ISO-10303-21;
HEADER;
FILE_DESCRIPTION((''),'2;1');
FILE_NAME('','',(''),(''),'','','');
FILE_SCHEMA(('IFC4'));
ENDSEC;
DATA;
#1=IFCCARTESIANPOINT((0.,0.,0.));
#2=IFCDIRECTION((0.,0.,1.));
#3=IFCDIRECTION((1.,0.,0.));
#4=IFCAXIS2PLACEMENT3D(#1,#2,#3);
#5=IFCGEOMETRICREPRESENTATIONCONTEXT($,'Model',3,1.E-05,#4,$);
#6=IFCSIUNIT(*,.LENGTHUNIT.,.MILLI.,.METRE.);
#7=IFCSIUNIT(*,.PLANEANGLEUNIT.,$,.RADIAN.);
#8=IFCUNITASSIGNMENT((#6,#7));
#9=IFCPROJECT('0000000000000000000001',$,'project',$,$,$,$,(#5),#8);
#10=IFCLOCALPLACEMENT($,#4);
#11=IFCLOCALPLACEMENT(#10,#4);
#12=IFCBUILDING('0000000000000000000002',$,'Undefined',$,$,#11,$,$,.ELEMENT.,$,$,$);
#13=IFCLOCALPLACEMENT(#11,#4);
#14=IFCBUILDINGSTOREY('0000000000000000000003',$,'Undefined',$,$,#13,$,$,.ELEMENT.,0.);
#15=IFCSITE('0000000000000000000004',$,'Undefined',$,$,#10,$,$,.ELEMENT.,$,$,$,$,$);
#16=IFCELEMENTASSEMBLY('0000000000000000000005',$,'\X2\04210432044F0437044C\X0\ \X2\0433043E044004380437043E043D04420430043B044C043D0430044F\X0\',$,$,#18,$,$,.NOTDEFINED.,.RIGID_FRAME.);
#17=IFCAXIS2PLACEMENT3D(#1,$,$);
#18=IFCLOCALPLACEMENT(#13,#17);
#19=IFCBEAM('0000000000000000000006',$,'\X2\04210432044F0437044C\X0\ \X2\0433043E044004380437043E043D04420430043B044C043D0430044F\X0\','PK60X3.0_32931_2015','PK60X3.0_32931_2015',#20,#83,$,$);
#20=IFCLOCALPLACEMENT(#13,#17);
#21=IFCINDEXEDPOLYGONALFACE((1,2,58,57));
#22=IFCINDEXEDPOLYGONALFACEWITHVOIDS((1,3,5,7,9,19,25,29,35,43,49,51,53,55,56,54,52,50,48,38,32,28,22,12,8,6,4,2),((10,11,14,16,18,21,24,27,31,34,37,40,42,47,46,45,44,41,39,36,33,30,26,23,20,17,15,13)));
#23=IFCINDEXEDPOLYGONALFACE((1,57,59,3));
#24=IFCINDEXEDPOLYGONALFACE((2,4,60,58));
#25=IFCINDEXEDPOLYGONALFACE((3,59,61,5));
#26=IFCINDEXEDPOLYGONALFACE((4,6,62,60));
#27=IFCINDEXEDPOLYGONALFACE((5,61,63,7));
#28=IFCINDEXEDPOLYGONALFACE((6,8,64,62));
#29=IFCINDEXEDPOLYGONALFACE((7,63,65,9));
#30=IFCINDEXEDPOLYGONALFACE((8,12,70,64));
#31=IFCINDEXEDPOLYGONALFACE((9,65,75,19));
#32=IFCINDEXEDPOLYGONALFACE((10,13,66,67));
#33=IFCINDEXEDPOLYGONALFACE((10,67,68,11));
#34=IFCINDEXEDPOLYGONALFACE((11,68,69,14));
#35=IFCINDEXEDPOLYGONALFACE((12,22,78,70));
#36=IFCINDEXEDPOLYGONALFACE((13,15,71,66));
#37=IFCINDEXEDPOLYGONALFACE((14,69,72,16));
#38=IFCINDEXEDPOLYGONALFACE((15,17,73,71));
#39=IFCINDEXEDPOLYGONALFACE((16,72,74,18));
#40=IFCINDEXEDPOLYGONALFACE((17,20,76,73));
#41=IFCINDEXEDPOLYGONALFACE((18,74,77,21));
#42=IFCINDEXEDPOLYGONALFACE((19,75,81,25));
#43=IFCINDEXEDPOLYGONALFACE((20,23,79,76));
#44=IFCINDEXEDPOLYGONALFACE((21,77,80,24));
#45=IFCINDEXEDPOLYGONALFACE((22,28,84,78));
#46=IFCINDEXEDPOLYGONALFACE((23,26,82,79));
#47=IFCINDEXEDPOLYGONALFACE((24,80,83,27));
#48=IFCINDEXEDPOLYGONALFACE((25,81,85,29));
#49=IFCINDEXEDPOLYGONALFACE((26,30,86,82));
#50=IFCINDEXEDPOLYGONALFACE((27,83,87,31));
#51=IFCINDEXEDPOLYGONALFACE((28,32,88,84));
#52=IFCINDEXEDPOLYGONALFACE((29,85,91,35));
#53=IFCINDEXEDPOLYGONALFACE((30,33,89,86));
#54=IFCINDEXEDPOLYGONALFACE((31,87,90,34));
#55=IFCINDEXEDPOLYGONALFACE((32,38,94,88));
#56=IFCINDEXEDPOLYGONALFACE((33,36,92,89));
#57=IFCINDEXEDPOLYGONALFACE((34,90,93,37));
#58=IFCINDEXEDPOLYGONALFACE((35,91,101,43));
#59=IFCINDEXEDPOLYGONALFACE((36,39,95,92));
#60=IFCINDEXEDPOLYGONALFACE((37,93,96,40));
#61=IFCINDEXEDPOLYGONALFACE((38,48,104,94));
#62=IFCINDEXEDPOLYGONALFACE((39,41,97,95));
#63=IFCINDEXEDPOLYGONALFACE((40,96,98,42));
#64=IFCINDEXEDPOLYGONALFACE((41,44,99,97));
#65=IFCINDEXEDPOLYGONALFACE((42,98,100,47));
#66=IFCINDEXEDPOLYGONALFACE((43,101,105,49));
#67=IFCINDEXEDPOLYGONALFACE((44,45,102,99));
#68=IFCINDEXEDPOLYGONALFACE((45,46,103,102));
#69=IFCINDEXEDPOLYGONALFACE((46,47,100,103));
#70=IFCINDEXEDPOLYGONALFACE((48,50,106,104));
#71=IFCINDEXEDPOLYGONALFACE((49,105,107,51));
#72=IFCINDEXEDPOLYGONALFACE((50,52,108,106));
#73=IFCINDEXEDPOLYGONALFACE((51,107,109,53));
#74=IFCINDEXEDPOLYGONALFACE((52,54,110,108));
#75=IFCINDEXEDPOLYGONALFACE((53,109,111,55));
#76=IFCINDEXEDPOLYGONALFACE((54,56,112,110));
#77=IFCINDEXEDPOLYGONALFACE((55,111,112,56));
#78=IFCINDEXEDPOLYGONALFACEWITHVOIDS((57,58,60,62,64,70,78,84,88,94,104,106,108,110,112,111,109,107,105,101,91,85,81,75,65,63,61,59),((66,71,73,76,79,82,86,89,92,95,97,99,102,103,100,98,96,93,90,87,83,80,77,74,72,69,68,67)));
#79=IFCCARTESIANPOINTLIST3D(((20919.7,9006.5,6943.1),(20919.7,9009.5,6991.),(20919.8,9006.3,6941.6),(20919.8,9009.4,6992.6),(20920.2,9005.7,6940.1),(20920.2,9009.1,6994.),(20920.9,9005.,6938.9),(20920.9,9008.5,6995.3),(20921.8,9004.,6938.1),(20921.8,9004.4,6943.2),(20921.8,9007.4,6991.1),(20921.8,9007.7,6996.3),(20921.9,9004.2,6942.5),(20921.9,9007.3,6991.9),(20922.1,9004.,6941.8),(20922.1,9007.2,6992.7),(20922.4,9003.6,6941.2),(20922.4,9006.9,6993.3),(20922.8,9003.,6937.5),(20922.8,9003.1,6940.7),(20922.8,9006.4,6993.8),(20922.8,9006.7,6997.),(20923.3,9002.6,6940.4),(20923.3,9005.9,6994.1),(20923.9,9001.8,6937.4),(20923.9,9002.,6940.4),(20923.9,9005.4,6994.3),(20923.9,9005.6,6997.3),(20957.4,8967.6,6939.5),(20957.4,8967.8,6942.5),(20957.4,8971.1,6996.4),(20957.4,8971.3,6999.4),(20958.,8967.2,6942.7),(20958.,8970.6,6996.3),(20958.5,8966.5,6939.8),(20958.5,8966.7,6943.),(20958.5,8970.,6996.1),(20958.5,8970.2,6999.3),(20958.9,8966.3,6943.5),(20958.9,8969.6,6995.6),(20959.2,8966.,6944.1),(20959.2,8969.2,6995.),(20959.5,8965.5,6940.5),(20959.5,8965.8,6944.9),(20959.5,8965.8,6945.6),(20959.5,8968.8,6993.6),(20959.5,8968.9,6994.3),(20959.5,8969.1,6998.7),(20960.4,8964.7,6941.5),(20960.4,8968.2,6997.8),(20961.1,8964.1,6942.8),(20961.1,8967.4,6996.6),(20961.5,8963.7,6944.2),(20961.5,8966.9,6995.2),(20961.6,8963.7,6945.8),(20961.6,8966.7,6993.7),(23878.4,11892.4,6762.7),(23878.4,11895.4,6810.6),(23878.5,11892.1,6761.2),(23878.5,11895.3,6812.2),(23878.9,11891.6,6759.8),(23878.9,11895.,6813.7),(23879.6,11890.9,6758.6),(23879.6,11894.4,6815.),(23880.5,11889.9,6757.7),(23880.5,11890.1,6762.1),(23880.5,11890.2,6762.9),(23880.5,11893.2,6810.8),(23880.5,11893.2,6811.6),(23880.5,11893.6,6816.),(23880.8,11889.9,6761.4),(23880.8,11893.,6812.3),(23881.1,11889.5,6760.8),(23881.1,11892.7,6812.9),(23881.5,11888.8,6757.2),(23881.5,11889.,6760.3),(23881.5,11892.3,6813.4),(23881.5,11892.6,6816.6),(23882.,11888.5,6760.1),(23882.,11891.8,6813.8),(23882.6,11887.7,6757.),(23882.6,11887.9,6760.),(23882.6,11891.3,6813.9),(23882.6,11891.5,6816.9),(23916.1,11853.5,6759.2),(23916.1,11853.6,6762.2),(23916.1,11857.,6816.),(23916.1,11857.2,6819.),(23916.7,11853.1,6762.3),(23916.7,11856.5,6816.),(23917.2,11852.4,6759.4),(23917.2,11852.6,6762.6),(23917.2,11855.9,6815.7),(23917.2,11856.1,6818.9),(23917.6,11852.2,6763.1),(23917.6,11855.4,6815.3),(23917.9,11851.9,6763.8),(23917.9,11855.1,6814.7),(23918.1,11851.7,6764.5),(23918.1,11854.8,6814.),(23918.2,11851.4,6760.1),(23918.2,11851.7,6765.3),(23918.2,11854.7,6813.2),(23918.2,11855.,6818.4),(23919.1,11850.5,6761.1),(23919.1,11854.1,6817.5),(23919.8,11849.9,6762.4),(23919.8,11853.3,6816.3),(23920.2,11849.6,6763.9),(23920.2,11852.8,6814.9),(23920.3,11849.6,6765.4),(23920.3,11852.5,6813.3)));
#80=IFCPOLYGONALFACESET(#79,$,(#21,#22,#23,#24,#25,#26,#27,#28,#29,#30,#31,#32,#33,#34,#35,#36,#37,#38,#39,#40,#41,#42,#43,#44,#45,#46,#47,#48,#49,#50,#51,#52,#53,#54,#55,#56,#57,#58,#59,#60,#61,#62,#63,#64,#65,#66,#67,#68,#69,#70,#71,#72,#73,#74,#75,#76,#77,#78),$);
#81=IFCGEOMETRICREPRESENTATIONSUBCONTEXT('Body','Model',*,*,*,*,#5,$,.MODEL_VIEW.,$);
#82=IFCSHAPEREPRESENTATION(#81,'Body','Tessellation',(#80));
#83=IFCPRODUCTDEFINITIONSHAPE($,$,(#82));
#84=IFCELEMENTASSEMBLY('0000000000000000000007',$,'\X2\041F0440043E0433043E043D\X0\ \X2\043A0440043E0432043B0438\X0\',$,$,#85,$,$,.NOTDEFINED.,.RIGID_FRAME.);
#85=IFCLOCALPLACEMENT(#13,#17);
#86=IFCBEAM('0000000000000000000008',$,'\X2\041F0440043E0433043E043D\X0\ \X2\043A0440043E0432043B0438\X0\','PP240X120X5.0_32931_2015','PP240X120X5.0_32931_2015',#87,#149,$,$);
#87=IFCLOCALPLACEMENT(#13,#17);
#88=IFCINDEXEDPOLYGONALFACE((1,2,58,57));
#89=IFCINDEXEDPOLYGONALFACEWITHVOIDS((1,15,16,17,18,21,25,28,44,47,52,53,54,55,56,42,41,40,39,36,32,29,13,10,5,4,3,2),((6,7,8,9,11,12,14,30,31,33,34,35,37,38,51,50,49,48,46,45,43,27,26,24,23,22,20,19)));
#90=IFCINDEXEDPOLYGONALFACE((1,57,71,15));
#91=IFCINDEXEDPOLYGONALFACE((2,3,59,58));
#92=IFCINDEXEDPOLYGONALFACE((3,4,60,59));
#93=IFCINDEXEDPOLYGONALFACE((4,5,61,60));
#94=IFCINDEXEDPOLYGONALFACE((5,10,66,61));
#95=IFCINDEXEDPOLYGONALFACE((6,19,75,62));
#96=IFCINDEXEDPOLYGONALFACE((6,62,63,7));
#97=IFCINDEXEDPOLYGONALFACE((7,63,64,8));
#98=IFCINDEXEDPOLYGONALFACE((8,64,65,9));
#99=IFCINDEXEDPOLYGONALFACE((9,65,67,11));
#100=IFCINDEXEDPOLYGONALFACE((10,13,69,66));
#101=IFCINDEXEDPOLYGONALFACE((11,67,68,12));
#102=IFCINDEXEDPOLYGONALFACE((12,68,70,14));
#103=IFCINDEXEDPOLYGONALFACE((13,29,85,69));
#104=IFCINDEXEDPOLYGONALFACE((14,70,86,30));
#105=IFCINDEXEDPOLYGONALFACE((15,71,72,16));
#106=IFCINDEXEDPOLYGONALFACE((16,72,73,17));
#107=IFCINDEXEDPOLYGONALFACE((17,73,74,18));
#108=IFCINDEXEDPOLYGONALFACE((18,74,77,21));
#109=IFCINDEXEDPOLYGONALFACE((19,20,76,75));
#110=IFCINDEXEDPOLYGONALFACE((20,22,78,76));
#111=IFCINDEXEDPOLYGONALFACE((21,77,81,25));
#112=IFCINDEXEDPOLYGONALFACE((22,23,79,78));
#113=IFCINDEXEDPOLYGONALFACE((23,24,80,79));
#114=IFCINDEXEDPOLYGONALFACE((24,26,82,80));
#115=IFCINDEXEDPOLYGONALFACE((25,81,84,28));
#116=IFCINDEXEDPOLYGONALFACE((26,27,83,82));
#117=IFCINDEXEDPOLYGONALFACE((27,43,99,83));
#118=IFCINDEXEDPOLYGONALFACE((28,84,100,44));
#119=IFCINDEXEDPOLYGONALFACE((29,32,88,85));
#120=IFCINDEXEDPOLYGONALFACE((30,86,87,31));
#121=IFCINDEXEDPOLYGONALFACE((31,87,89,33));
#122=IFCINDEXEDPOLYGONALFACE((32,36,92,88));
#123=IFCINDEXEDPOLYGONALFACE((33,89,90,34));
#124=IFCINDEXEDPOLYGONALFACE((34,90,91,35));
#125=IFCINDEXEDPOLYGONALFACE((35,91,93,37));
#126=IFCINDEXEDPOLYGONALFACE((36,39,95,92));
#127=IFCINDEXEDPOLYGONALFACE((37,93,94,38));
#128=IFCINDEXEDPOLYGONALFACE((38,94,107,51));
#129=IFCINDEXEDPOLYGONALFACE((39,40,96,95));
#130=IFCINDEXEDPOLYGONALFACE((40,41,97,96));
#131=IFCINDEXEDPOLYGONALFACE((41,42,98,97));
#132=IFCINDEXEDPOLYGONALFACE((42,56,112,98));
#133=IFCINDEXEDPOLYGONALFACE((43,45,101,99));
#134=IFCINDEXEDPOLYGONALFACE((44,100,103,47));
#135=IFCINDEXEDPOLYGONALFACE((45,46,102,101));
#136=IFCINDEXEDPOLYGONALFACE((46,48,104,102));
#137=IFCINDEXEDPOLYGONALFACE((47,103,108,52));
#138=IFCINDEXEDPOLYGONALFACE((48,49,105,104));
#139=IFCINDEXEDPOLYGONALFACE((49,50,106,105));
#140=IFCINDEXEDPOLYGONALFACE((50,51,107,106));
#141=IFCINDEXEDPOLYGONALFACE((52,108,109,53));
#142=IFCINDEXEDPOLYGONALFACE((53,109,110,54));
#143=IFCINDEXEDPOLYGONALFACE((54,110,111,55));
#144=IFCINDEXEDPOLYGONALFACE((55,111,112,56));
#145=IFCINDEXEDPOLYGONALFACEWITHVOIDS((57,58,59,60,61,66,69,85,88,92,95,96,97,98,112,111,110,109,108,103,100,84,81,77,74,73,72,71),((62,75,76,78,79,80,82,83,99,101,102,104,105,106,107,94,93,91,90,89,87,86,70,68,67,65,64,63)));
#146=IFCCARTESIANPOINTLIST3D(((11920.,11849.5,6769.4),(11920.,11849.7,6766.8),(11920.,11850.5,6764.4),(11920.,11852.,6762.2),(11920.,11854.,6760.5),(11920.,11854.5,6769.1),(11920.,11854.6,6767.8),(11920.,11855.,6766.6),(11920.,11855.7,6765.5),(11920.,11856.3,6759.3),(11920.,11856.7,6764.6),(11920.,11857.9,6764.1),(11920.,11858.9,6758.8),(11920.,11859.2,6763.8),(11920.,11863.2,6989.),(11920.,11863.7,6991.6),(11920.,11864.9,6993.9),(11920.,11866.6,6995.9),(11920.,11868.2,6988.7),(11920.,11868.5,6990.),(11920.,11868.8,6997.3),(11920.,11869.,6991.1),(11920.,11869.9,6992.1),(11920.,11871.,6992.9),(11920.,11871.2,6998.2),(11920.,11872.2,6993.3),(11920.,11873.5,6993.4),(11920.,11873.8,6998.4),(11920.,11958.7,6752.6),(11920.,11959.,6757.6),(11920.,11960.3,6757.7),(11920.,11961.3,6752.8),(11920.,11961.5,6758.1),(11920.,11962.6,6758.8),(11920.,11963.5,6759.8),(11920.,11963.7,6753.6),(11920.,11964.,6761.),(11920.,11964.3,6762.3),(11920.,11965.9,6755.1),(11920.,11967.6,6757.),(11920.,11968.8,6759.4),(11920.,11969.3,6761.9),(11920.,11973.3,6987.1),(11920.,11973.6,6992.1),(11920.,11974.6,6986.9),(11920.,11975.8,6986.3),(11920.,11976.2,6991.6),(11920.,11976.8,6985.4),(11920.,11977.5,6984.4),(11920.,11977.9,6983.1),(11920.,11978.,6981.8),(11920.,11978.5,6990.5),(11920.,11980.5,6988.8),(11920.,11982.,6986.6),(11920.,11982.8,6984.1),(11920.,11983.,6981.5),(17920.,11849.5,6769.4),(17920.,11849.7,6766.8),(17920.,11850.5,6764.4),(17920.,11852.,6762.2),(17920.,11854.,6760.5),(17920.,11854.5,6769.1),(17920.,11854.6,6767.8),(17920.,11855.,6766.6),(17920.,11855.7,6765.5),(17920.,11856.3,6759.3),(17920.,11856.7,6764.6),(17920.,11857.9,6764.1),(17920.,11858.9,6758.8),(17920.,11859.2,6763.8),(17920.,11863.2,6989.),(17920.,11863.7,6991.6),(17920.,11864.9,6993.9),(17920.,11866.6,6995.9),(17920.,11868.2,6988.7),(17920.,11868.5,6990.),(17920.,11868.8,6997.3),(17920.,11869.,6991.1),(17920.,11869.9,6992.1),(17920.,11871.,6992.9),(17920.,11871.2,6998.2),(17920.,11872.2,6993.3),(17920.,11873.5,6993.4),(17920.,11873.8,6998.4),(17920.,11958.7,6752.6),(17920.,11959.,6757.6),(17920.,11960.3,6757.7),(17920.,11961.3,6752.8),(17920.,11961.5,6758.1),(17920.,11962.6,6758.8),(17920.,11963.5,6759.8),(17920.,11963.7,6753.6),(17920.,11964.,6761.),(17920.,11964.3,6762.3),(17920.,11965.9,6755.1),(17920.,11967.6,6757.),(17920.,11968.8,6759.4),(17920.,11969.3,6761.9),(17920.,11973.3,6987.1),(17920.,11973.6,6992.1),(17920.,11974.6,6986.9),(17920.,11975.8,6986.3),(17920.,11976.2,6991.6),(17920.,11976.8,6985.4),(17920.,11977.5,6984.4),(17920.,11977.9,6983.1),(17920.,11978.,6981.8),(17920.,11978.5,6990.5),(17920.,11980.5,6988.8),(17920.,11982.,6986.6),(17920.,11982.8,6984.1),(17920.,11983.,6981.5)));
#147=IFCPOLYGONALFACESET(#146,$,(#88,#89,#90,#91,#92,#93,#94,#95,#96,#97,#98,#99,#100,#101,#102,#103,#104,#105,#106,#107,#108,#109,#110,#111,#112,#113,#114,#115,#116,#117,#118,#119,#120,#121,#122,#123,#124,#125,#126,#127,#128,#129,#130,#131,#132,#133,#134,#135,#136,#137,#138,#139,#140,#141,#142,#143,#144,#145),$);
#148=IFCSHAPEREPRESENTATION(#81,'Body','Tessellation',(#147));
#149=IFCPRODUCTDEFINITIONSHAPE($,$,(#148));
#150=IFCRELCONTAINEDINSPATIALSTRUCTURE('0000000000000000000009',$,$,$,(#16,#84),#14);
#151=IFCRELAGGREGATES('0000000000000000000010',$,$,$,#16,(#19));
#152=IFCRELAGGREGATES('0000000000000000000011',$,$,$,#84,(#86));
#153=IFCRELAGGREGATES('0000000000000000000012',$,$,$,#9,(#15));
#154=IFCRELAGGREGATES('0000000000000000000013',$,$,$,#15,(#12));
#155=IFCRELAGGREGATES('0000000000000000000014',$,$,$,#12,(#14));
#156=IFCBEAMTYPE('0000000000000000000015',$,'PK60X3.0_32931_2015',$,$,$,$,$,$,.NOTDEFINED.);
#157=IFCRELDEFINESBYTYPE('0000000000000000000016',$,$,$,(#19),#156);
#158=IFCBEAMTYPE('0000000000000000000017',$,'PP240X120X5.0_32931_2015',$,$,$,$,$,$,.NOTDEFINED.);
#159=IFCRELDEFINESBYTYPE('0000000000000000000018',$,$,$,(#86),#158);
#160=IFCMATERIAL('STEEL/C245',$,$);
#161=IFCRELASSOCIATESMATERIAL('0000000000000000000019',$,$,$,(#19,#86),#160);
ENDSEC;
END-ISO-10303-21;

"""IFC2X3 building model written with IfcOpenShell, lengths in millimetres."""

from ifc_helpers import new_model, si_unit, frame, origin_with_axes, origin_2d_with_axis, place, context, subcontext, project, spatial, hollow_rectangle, extrude, material, type_object, element, aggregate, save


model = new_model("IFC2X3")

# Units and contexts
model_context = context("Model", 3, precision=1e-05, world=origin_with_axes())
body_context = subcontext(model_context, "Body", "Model", "MODEL_VIEW")
ifc_project = project(units=[si_unit("LENGTHUNIT", "METRE", prefix="MILLI"), si_unit("PLANEANGLEUNIT", "RADIAN")], contexts=[model_context])

# Site, building, storey
site_placement = place(None, origin_with_axes())
site = spatial("IfcSite", under=ifc_project, at=site_placement, Name="Undefined", CompositionType="ELEMENT")
building_placement = place(site_placement, origin_with_axes())
building = spatial("IfcBuilding", under=site, at=building_placement, Name="Undefined", CompositionType="ELEMENT")
storey_placement = place(building_placement, origin_with_axes())
storey = spatial("IfcBuildingStorey", under=building, at=storey_placement, Name="Undefined", CompositionType="ELEMENT", Elevation=0.0)

# Shared definitions
ifc_material = material(Name="STEEL/C245")

# Element assemblies, beams
beam_type_1 = type_object("IfcBeamType", Name="PK60X3.0_32931_2015", PredefinedType="NOTDEFINED")
assembly_1_placement = place(storey_placement, origin_with_axes())
assembly_1 = element("IfcElementAssembly", 1, at=assembly_1_placement, inside=storey, Name="Связь горизонтальная", AssemblyPlace="NOTDEFINED", PredefinedType="RIGID_FRAME")
beam_1_placement = place(assembly_1_placement, frame((23899.3, 11872.5, 6788.0), z_axis=(0.0, 0.062378, 0.998053), x_axis=(-0.715179, -0.69758, 0.043599)))
beam_1 = element("IfcBeam", 2, at=beam_1_placement, type_object=beam_type_1, material=ifc_material, Name="Связь горизонтальная", Description="PK60X3.0_32931_2015", ObjectType="PK60X3.0_32931_2015", context=body_context, shape_type="SweptSolid", body=[
    extrude(hollow_rectangle(XDim=60.0, YDim=60.0, WallThickness=3.0, InnerFilletRadius=3.0, OuterFilletRadius=6.0, at=origin_2d_with_axis()), frame((4137.0, 0.0, 0.0), z_axis=(-1.0, 0.0, 0.0), x_axis=(0.0, -1.0, 0.0)), (0.0, 0.0, 1.0), 4137.0),
])
aggregate(assembly_1, [beam_1])
assembly_2_placement = place(storey_placement, origin_with_axes())
assembly_2 = element("IfcElementAssembly", 3, at=assembly_2_placement, inside=storey, Name="Прогон кровли", AssemblyPlace="NOTDEFINED", PredefinedType="RIGID_FRAME")
beam_type_2 = type_object("IfcBeamType", Name="PP240X120X5.0_32931_2015", PredefinedType="NOTDEFINED")
beam_2_placement = place(assembly_2_placement, frame((17920.0, 11916.2, 6875.5), z_axis=(0.0, 0.062378, 0.998053), x_axis=(-1.0, 0.0, 0.0)))
beam_2 = element("IfcBeam", 4, at=beam_2_placement, type_object=beam_type_2, material=ifc_material, Name="Прогон кровли", Description="PP240X120X5.0_32931_2015", ObjectType="PP240X120X5.0_32931_2015", context=body_context, shape_type="SweptSolid", body=[
    extrude(hollow_rectangle(XDim=120.0, YDim=240.0, WallThickness=5.0, InnerFilletRadius=5.0, OuterFilletRadius=10.0, at=origin_2d_with_axis()), frame((6000.0, 0.0, 0.0), z_axis=(-1.0, 0.0, 0.0), x_axis=(0.0, -1.0, 0.0)), (0.0, 0.0, 1.0), 6000.0),
])
aggregate(assembly_2, [beam_2])

save(model, "model.ifc")
